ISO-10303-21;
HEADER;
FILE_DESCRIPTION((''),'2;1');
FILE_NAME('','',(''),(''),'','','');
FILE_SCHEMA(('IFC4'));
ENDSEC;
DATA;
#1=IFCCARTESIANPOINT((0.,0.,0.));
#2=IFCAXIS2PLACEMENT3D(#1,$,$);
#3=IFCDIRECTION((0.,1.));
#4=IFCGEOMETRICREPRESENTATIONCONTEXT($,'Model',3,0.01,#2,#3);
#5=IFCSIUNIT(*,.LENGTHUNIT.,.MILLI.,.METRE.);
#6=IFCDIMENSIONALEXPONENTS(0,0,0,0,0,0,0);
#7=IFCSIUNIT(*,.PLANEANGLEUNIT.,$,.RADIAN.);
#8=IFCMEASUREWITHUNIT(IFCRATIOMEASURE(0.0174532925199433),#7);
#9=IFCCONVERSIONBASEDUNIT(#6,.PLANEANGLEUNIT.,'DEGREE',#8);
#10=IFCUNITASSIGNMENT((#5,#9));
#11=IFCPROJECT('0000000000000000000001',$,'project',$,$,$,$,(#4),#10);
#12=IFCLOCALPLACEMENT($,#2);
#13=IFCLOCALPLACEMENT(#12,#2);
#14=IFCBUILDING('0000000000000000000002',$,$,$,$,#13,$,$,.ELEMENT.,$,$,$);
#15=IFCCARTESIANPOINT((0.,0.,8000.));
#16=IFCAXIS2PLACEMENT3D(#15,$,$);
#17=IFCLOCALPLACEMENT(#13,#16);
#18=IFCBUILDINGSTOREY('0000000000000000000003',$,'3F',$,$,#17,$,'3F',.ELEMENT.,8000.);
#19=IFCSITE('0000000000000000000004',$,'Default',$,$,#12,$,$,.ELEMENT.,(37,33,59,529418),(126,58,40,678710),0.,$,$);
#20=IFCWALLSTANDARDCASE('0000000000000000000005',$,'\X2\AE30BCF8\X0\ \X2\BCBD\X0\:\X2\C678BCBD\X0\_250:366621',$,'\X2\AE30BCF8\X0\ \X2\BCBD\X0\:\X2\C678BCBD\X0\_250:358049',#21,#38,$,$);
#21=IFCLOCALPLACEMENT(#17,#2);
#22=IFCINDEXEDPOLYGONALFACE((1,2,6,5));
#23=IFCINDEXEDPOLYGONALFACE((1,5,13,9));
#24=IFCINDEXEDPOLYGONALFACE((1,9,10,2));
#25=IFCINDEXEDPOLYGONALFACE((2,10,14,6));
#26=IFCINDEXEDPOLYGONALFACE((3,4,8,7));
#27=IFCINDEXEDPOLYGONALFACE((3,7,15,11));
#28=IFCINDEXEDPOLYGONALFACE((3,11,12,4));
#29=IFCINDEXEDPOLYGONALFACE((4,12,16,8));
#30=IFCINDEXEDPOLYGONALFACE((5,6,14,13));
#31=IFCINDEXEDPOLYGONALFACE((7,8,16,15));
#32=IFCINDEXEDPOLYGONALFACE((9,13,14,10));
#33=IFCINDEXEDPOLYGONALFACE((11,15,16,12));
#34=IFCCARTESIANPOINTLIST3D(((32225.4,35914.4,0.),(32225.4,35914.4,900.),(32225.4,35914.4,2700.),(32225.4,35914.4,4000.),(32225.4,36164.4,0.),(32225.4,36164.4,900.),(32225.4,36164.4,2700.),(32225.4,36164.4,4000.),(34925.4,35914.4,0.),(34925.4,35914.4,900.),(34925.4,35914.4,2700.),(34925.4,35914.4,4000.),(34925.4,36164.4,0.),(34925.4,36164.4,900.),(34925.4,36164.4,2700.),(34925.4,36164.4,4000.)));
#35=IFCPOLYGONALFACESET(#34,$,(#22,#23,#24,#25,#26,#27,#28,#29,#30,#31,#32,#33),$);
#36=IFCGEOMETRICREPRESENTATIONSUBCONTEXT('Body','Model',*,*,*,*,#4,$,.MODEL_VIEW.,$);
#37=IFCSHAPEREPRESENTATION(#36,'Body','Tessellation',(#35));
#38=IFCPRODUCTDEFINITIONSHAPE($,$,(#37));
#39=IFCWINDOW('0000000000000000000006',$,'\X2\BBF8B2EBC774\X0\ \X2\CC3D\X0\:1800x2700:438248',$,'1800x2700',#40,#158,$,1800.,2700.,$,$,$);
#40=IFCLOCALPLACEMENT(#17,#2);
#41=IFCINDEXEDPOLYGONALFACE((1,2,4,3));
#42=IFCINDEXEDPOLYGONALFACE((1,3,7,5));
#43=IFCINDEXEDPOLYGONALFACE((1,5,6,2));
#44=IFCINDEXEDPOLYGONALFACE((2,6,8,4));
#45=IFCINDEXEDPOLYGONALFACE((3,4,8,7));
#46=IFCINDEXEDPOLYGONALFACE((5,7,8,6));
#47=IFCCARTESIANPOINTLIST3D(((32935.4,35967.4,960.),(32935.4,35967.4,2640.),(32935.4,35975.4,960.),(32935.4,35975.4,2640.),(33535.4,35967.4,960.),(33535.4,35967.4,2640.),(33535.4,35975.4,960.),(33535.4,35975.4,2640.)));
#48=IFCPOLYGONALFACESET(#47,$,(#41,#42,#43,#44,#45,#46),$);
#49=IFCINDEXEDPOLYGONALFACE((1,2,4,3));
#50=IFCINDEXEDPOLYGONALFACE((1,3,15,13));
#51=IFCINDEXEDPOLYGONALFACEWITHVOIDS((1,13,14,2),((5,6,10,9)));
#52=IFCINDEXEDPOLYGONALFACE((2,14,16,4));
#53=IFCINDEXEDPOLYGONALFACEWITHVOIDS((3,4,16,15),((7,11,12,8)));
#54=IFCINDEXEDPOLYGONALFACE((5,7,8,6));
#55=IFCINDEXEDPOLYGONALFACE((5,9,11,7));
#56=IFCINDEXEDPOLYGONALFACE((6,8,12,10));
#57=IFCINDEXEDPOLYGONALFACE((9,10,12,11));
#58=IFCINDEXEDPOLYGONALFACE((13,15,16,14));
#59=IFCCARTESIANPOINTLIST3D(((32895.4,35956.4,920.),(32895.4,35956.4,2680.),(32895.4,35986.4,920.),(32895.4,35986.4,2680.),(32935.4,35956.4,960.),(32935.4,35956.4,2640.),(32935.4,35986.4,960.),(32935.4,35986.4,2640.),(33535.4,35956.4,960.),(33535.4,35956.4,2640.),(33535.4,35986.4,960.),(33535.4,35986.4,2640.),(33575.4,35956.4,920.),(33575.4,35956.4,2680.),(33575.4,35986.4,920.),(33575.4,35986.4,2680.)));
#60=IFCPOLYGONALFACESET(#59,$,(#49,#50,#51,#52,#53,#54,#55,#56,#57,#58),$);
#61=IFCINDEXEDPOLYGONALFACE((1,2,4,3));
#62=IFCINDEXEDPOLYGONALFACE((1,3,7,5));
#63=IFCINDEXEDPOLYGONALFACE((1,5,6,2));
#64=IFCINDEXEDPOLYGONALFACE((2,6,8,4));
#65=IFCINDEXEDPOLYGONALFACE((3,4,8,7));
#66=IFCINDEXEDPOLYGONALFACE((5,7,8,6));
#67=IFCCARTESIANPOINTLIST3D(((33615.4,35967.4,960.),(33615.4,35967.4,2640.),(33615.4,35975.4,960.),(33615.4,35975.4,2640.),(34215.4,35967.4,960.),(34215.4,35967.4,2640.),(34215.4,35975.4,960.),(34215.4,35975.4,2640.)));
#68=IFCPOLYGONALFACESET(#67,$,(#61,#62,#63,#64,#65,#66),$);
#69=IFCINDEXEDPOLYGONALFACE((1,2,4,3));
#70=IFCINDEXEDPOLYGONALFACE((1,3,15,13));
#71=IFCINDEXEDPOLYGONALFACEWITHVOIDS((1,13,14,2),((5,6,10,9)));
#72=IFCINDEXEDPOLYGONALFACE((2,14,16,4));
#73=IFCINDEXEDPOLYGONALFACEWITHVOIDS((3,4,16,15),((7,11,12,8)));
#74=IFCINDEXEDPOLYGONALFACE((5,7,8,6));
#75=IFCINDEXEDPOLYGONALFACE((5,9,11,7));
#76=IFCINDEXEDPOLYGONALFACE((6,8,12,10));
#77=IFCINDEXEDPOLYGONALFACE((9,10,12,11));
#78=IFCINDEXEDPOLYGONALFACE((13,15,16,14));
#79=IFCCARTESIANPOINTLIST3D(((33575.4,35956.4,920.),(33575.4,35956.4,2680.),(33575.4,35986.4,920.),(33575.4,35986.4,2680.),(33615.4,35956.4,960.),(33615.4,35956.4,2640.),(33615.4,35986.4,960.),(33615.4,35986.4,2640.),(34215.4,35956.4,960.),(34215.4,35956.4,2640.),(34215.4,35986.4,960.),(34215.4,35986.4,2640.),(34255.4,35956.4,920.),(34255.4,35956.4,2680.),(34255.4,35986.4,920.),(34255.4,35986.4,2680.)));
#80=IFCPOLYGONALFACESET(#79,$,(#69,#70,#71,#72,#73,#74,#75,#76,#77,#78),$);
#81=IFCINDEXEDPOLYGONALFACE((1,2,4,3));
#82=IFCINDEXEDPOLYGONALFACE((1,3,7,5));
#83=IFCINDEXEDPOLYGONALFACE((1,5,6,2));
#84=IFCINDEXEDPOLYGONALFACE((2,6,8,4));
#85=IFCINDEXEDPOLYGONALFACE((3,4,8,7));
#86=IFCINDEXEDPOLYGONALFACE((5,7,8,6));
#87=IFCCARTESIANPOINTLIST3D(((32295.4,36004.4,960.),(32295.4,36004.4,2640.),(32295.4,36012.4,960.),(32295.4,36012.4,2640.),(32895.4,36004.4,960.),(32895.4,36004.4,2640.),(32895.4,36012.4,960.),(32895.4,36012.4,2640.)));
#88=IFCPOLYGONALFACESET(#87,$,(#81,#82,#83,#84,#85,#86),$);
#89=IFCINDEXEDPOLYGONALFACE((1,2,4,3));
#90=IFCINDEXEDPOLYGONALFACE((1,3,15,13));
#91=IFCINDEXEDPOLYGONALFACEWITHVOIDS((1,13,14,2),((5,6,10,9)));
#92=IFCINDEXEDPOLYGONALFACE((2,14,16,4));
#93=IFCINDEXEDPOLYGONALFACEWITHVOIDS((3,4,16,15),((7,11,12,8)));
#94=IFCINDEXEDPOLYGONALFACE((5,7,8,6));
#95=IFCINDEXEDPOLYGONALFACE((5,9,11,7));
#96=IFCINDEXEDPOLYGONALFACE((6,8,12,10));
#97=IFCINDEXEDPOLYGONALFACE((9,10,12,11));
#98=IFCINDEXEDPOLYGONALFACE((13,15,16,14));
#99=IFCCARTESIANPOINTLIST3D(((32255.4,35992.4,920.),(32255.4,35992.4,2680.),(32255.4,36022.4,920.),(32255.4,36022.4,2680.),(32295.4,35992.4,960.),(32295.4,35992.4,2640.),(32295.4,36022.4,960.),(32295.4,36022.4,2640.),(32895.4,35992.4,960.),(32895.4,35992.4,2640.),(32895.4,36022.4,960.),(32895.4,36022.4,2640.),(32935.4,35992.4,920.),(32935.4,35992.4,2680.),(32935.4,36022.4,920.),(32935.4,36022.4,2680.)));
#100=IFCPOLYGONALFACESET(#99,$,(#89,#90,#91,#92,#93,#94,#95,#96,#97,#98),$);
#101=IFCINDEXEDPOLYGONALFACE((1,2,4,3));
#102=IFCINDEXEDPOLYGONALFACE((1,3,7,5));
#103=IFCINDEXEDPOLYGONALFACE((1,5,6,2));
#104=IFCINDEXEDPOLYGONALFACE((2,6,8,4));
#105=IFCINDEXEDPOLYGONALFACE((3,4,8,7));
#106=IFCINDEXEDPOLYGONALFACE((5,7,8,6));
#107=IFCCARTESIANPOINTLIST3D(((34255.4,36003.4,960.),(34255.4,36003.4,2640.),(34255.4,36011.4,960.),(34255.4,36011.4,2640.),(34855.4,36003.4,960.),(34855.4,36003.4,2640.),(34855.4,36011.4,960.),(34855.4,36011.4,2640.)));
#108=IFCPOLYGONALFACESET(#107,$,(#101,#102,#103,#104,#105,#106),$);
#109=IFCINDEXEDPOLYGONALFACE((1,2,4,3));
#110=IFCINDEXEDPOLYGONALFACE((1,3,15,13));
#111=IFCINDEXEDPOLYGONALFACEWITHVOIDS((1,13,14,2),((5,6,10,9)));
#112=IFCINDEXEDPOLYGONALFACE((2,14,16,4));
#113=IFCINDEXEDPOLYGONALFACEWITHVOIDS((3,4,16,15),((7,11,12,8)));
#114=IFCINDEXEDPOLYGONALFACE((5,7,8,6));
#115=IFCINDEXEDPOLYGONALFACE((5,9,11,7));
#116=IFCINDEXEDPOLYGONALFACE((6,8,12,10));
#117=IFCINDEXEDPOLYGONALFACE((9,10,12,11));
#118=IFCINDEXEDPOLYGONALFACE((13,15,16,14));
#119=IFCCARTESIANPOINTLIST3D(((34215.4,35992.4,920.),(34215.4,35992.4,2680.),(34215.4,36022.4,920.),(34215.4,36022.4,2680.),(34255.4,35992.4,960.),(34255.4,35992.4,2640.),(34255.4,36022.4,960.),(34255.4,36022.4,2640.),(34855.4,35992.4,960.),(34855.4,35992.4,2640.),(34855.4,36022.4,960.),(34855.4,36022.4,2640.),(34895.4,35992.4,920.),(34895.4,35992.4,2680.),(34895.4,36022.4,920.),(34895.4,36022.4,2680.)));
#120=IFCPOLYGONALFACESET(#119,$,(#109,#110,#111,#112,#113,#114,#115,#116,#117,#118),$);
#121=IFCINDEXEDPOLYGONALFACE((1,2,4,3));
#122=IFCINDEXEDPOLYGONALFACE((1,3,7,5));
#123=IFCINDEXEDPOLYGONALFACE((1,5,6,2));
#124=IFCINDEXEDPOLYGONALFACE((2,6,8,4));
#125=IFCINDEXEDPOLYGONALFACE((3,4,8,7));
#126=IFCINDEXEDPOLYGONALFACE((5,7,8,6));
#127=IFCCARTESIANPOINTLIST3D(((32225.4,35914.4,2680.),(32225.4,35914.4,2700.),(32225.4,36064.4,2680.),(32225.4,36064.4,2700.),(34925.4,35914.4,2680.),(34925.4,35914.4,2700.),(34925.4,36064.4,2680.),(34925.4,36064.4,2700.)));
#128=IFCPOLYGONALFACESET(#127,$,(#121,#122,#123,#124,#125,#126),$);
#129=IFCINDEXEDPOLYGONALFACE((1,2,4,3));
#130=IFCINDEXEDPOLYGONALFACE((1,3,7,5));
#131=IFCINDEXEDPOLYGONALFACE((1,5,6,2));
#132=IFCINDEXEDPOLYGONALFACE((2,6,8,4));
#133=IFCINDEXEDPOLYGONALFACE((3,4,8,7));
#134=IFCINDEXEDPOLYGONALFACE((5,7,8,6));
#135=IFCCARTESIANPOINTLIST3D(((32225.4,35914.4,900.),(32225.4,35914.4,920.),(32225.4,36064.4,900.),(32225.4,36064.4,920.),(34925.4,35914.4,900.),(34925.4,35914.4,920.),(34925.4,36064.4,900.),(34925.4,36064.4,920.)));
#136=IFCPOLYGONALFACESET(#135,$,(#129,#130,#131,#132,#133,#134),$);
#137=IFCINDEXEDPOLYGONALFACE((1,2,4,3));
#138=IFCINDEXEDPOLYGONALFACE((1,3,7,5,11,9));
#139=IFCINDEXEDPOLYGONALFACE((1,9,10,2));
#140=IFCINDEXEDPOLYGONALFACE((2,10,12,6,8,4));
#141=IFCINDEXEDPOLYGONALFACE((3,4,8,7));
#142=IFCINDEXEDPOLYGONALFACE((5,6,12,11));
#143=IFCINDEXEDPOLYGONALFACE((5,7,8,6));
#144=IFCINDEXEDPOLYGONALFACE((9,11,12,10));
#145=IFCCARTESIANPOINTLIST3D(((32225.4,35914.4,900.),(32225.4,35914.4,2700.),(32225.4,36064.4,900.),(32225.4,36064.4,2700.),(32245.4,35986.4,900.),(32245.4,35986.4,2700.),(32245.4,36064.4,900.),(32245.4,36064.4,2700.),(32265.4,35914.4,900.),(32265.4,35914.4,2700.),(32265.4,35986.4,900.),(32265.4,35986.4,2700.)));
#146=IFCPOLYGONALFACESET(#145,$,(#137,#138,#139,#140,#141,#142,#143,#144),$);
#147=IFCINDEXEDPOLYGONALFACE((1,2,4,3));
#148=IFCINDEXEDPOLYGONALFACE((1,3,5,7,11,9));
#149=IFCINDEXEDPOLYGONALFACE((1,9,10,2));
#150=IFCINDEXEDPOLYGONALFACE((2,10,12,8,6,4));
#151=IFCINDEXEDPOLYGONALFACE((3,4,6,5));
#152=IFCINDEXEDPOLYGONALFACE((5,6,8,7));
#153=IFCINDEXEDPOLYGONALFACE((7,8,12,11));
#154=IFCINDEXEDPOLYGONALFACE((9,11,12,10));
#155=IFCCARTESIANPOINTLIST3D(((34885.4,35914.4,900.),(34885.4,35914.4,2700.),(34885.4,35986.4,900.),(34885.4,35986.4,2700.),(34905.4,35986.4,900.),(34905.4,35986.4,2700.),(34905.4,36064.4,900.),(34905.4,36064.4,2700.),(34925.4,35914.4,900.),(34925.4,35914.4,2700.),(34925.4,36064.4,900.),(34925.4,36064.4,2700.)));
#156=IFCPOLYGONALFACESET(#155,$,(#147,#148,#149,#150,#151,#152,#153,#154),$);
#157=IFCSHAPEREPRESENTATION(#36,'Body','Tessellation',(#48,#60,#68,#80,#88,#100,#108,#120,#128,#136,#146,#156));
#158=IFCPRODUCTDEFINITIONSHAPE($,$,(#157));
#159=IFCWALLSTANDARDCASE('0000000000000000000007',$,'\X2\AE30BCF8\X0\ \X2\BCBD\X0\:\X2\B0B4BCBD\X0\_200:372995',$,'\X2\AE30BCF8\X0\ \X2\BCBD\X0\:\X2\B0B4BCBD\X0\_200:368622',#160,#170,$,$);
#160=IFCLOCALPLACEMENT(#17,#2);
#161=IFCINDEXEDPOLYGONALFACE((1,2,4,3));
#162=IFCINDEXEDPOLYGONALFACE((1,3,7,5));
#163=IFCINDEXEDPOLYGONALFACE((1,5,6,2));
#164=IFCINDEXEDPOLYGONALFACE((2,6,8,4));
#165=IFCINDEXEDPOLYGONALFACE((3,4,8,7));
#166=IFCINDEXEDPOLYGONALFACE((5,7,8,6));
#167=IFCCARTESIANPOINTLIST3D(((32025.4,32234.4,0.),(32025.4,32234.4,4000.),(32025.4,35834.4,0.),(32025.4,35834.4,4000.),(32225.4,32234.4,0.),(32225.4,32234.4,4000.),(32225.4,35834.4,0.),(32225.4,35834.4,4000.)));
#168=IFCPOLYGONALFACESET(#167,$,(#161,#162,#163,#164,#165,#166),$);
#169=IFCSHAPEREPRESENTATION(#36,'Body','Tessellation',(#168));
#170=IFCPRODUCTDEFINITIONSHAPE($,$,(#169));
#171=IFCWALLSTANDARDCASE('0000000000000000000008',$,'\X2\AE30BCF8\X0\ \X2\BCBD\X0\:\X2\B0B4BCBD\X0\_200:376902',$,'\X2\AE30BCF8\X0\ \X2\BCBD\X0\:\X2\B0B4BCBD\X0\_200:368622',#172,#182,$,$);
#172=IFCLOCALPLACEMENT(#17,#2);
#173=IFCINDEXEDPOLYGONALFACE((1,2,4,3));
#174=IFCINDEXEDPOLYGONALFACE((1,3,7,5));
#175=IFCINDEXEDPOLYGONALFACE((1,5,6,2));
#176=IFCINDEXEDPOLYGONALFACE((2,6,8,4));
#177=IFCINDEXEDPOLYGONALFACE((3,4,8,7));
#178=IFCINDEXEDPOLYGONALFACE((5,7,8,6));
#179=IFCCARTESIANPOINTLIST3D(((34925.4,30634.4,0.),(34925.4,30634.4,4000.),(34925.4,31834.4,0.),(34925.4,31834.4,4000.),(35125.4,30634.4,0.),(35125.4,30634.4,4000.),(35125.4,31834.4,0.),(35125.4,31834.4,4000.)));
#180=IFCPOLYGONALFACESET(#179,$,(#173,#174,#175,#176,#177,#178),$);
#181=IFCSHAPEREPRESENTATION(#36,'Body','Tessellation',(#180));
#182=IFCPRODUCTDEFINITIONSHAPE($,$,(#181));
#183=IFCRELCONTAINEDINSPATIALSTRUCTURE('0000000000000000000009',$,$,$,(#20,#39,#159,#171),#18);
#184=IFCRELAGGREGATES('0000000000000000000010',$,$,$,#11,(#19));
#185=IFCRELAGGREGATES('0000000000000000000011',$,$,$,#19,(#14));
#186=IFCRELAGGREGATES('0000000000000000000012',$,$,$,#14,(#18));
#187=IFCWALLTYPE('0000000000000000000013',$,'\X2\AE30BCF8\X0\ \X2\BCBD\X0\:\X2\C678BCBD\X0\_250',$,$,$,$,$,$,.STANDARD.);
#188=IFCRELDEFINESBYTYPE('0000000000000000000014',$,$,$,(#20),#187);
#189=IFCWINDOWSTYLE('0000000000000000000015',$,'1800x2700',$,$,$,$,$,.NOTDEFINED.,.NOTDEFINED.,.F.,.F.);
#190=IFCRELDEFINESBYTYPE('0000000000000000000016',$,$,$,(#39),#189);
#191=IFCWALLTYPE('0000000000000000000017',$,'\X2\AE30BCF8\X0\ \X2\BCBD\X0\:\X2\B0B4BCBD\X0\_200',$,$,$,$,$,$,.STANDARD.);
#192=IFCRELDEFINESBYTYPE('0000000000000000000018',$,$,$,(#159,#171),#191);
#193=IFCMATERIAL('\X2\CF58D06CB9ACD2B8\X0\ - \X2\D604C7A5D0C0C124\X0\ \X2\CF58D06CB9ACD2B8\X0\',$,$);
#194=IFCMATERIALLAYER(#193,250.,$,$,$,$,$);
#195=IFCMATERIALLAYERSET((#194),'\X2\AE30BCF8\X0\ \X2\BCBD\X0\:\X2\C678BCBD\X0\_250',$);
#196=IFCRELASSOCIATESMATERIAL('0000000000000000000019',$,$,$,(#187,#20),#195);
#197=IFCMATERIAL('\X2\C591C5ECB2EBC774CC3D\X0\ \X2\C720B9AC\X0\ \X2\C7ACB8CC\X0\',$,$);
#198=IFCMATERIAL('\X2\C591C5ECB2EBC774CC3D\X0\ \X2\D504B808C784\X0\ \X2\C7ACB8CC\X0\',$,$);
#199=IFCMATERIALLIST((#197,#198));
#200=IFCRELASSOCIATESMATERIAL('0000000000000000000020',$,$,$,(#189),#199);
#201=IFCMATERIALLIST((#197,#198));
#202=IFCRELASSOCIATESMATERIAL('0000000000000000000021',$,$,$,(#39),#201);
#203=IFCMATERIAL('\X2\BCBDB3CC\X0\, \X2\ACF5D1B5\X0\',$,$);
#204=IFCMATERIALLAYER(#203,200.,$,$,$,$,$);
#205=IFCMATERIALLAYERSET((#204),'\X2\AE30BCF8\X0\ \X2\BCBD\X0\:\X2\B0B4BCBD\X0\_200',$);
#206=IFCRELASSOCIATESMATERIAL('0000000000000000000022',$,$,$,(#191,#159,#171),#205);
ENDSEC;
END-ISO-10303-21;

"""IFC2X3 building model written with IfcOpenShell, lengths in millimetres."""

from ifc_helpers import new_model, entity, si_unit, converted_unit, direction, frame, frame_2d, origin, origin_2d_with_axis, place, context, subcontext, project, spatial, polyline, rectangle, outline, extrude, source, transform, mapped, material, material_list, layer, layer_set, layer_usage, type_object, type_shapes, element, fill, save


model = new_model("IFC2X3")

# Units and contexts
model_context = context("Model", 3, precision=0.01, world=origin(), true_north=direction((0.0, 1.0)))
body_context = subcontext(model_context, "Body", "Model", "MODEL_VIEW")
ifc_project = project(units=[si_unit("LENGTHUNIT", "METRE", prefix="MILLI"), converted_unit("PLANEANGLEUNIT", "DEGREE", entity("IfcRatioMeasure", 0.0174532925199433), si_unit("PLANEANGLEUNIT", "RADIAN"), dimensions=[0, 0, 0, 0, 0, 0, 0])], contexts=[model_context])

# Site, building, storey
site_placement = place(None, origin())
site = spatial("IfcSite", under=ifc_project, at=site_placement, Name="Default", CompositionType="ELEMENT", RefLatitude=(37, 33, 59, 529418), RefLongitude=(126, 58, 40, 678710), RefElevation=0.0)
building_placement = place(site_placement, origin())
building = spatial("IfcBuilding", under=site, at=building_placement, CompositionType="ELEMENT")
storey_placement = place(building_placement, frame((0.0, 0.0, 8000.0)))
storey = spatial("IfcBuildingStorey", under=building, at=storey_placement, Name="3F", LongName="3F", CompositionType="ELEMENT", Elevation=8000.0)

# Shared definitions
ifc_material_1 = material(Name="콘크리트 - 현장타설 콘크리트")

# Shared definitions
ifc_material_2 = material(Name="양여닫이창 유리 재료")
ifc_material_3 = material(Name="양여닫이창 프레임 재료")

# Shared definitions
ifc_layer_1 = layer(ifc_material_1, 250.0)
ifc_layer_set_1 = layer_set([ifc_layer_1], Name="기본 벽:외벽_250")
wall_type_1 = type_object("IfcWallType", Name="기본 벽:외벽_250", PredefinedType="STANDARD", material=ifc_layer_set_1)

# Wall, opening, window
ifc_layer_usage_1 = layer_usage(ifc_layer_set_1, "AXIS2", "NEGATIVE", 125.0)
wall_1_placement = place(storey_placement, frame((34925.4, 36039.4, 0.0), z_axis=(0.0, 0.0, 1.0), x_axis=(-1.0, 0.0, 0.0)))
wall_1 = element("IfcWallStandardCase", 1, at=wall_1_placement, inside=storey, type_object=wall_type_1, material=ifc_layer_usage_1, Name="기본 벽:외벽_250:366621", ObjectType="기본 벽:외벽_250:358049", context=body_context, shape_type="SweptSolid", body=[
    extrude(rectangle(XDim=2700.0, YDim=250.0, at=frame_2d((1350.0, 0.0), x_axis=(-1.0, 0.0))), origin(), (0.0, 0.0, 1.0), 4000.0),
])
opening_1_placement = place(wall_1_placement, frame((0.0, -125.0, 900.0)))
opening_1 = element("IfcOpeningElement", 2, at=opening_1_placement, cuts=wall_1, ObjectType="Opening", context=body_context, shape_type="SweptSolid", body=[
    extrude(rectangle(XDim=1800.0, YDim=2700.0, at=frame_2d((900.0, 1350.0), x_axis=(1.0, 0.0))), frame((0.0, 0.0, 0.0), z_axis=(0.0, 1.0, 0.0), x_axis=(0.0, 0.0, 1.0)), (0.0, 0.0, 1.0), 250.0),
])
ifc_material_list_1 = material_list([ifc_material_2, ifc_material_3])
ifc_material_list_2 = material_list([ifc_material_2, ifc_material_3])
window_style_1 = type_object("IfcWindowStyle", Name="1800x2700", ConstructionType="NOTDEFINED", OperationType="NOTDEFINED", ParameterTakesPrecedence=False, Sizeable=False, material=ifc_material_list_2)
shared_shape_1 = source(origin(), body_context, "Body", "SweptSolid", [
    extrude(rectangle(XDim=8.0, YDim=600.0, at=frame_2d((0.0, 0.0), x_axis=(1.0, 0.0))), frame((1690.0, 193.0, 60.0), z_axis=(0.0, 0.0, 1.0), x_axis=(0.0, 1.0, 0.0)), (0.0, 0.0, 1.0), 1680.0),
    extrude(outline(polyline([(-880.0, -340.0), (880.0, -340.0), (880.0, 340.0), (-880.0, 340.0), (-880.0, -340.0)]), holes=[polyline([(840.0, -300.0), (-840.0, -300.0), (-840.0, 300.0), (840.0, 300.0), (840.0, -300.0)])]), frame((1690.0, 178.0, 900.0), z_axis=(0.0, 1.0, 0.0), x_axis=(0.0, 0.0, -1.0)), (0.0, 0.0, 1.0), 30.0),
    extrude(rectangle(XDim=8.0, YDim=600.0, at=origin_2d_with_axis()), frame((1010.0, 193.0, 60.0), z_axis=(0.0, 0.0, 1.0), x_axis=(0.0, 1.0, 0.0)), (0.0, 0.0, 1.0), 1680.0),
    extrude(outline(polyline([(-880.0, -340.0), (880.0, -340.0), (880.0, 340.0), (-880.0, 340.0), (-880.0, -340.0)]), holes=[polyline([(840.0, -300.0), (-840.0, -300.0), (-840.0, 300.0), (840.0, 300.0), (840.0, -300.0)])]), frame((1010.0, 178.0, 900.0), z_axis=(0.0, 1.0, 0.0), x_axis=(0.0, 0.0, -1.0)), (0.0, 0.0, 1.0), 30.0),
    extrude(rectangle(XDim=8.0, YDim=600.0, at=frame_2d((0.0, 0.0), x_axis=(1.0, 0.0))), frame((2330.0, 156.0, 60.0), z_axis=(0.0, 0.0, 1.0), x_axis=(0.0, 1.0, 0.0)), (0.0, 0.0, 1.0), 1680.0),
    extrude(outline(polyline([(-880.0, -340.0), (880.0, -340.0), (880.0, 340.0), (-880.0, 340.0), (-880.0, -340.0)]), holes=[polyline([(840.0, -300.0), (-840.0, -300.0), (-840.0, 300.0), (840.0, 300.0), (840.0, -300.0)])]), frame((2330.0, 142.0, 900.0), z_axis=(0.0, 1.0, 0.0), x_axis=(0.0, 0.0, -1.0)), (0.0, 0.0, 1.0), 30.0),
    extrude(rectangle(XDim=8.0, YDim=600.0, at=frame_2d((0.0, 0.0), x_axis=(1.0, 0.0))), frame((370.0, 157.0, 60.0), z_axis=(0.0, 0.0, 1.0), x_axis=(0.0, 1.0, 0.0)), (0.0, 0.0, 1.0), 1680.0),
    extrude(outline(polyline([(-880.0, -340.0), (880.0, -340.0), (880.0, 340.0), (-880.0, 340.0), (-880.0, -340.0)]), holes=[polyline([(840.0, -300.0), (-840.0, -300.0), (-840.0, 300.0), (840.0, 300.0), (840.0, -300.0)])]), frame((370.0, 142.0, 900.0), z_axis=(0.0, 1.0, 0.0), x_axis=(0.0, 0.0, -1.0)), (0.0, 0.0, 1.0), 30.0),
    extrude(rectangle(XDim=2700.0, YDim=150.0, at=origin_2d_with_axis()), frame((1350.0, 175.0, 1780.0), z_axis=(0.0, 0.0, 1.0), x_axis=(-1.0, 0.0, 0.0)), (0.0, 0.0, 1.0), 20.0),
    extrude(rectangle(XDim=2700.0, YDim=150.0, at=origin_2d_with_axis()), frame((1350.0, 175.0, 0.0), z_axis=(0.0, 0.0, 1.0), x_axis=(-1.0, 0.0, 0.0)), (0.0, 0.0, 1.0), 20.0),
    extrude(outline(polyline([(-74.0, -20.0), (-2.0, -20.0), (-2.0, 0.0), (76.0, 0.0), (76.0, 20.0), (-74.0, 20.0), (-74.0, -20.0)])), frame((2680.0, 176.0, 0.0), z_axis=(0.0, 0.0, 1.0), x_axis=(0.0, -1.0, 0.0)), (0.0, 0.0, 1.0), 1800.0),
    extrude(outline(polyline([(-20.0, -74.0), (20.0, -74.0), (20.0, 76.0), (0.0, 76.0), (0.0, -2.0), (-20.0, -2.0), (-20.0, -74.0)])), frame((20.0, 176.0, 0.0), z_axis=(0.0, 0.0, 1.0), x_axis=(-1.0, 0.0, 0.0)), (0.0, 0.0, 1.0), 1800.0),
])
type_shapes(window_style_1, [shared_shape_1])
window_1_placement = place(opening_1_placement, origin())
window_1 = element("IfcWindow", 3, at=window_1_placement, inside=storey, type_object=window_style_1, material=ifc_material_list_1, Name="미닫이 창:1800x2700:438248", ObjectType="1800x2700", OverallHeight=1800.0, OverallWidth=2700.0, context=body_context, shape_type="MappedRepresentation", body=[
    mapped(shared_shape_1, transform((0.0, 0.0, 0.0), scale=1.0)),
])
fill(opening_1, window_1)

# Walls
ifc_material_4 = material(Name="벽돌, 공통")
ifc_layer_2 = layer(ifc_material_4, 200.0)
ifc_layer_set_2 = layer_set([ifc_layer_2], Name="기본 벽:내벽_200")
ifc_layer_usage_2 = layer_usage(ifc_layer_set_2, "AXIS2", "NEGATIVE", 100.0)
wall_type_2 = type_object("IfcWallType", Name="기본 벽:내벽_200", PredefinedType="STANDARD", material=ifc_layer_set_2)
wall_2_placement = place(storey_placement, frame((32125.4, 35834.4, 0.0), z_axis=(0.0, 0.0, 1.0), x_axis=(0.0, -1.0, 0.0)))
element("IfcWallStandardCase", 4, at=wall_2_placement, inside=storey, type_object=wall_type_2, material=ifc_layer_usage_2, Name="기본 벽:내벽_200:372995", ObjectType="기본 벽:내벽_200:368622", context=body_context, shape_type="SweptSolid", body=[
    extrude(rectangle(XDim=3600.0, YDim=200.0, at=frame_2d((1800.0, 0.0), x_axis=(-1.0, 0.0))), origin(), (0.0, 0.0, 1.0), 4000.0),
])
ifc_layer_usage_3 = layer_usage(ifc_layer_set_2, "AXIS2", "NEGATIVE", 100.0)
wall_3_placement = place(storey_placement, frame((35025.4, 31834.4, 0.0), z_axis=(0.0, 0.0, 1.0), x_axis=(0.0, -1.0, 0.0)))
element("IfcWallStandardCase", 5, at=wall_3_placement, inside=storey, type_object=wall_type_2, material=ifc_layer_usage_3, Name="기본 벽:내벽_200:376902", ObjectType="기본 벽:내벽_200:368622", context=body_context, shape_type="SweptSolid", body=[
    extrude(rectangle(XDim=1200.0, YDim=200.0, at=frame_2d((600.0, 0.0), x_axis=(-1.0, 0.0))), origin(), (0.0, 0.0, 1.0), 4000.0),
])

save(model, "model.ifc")
